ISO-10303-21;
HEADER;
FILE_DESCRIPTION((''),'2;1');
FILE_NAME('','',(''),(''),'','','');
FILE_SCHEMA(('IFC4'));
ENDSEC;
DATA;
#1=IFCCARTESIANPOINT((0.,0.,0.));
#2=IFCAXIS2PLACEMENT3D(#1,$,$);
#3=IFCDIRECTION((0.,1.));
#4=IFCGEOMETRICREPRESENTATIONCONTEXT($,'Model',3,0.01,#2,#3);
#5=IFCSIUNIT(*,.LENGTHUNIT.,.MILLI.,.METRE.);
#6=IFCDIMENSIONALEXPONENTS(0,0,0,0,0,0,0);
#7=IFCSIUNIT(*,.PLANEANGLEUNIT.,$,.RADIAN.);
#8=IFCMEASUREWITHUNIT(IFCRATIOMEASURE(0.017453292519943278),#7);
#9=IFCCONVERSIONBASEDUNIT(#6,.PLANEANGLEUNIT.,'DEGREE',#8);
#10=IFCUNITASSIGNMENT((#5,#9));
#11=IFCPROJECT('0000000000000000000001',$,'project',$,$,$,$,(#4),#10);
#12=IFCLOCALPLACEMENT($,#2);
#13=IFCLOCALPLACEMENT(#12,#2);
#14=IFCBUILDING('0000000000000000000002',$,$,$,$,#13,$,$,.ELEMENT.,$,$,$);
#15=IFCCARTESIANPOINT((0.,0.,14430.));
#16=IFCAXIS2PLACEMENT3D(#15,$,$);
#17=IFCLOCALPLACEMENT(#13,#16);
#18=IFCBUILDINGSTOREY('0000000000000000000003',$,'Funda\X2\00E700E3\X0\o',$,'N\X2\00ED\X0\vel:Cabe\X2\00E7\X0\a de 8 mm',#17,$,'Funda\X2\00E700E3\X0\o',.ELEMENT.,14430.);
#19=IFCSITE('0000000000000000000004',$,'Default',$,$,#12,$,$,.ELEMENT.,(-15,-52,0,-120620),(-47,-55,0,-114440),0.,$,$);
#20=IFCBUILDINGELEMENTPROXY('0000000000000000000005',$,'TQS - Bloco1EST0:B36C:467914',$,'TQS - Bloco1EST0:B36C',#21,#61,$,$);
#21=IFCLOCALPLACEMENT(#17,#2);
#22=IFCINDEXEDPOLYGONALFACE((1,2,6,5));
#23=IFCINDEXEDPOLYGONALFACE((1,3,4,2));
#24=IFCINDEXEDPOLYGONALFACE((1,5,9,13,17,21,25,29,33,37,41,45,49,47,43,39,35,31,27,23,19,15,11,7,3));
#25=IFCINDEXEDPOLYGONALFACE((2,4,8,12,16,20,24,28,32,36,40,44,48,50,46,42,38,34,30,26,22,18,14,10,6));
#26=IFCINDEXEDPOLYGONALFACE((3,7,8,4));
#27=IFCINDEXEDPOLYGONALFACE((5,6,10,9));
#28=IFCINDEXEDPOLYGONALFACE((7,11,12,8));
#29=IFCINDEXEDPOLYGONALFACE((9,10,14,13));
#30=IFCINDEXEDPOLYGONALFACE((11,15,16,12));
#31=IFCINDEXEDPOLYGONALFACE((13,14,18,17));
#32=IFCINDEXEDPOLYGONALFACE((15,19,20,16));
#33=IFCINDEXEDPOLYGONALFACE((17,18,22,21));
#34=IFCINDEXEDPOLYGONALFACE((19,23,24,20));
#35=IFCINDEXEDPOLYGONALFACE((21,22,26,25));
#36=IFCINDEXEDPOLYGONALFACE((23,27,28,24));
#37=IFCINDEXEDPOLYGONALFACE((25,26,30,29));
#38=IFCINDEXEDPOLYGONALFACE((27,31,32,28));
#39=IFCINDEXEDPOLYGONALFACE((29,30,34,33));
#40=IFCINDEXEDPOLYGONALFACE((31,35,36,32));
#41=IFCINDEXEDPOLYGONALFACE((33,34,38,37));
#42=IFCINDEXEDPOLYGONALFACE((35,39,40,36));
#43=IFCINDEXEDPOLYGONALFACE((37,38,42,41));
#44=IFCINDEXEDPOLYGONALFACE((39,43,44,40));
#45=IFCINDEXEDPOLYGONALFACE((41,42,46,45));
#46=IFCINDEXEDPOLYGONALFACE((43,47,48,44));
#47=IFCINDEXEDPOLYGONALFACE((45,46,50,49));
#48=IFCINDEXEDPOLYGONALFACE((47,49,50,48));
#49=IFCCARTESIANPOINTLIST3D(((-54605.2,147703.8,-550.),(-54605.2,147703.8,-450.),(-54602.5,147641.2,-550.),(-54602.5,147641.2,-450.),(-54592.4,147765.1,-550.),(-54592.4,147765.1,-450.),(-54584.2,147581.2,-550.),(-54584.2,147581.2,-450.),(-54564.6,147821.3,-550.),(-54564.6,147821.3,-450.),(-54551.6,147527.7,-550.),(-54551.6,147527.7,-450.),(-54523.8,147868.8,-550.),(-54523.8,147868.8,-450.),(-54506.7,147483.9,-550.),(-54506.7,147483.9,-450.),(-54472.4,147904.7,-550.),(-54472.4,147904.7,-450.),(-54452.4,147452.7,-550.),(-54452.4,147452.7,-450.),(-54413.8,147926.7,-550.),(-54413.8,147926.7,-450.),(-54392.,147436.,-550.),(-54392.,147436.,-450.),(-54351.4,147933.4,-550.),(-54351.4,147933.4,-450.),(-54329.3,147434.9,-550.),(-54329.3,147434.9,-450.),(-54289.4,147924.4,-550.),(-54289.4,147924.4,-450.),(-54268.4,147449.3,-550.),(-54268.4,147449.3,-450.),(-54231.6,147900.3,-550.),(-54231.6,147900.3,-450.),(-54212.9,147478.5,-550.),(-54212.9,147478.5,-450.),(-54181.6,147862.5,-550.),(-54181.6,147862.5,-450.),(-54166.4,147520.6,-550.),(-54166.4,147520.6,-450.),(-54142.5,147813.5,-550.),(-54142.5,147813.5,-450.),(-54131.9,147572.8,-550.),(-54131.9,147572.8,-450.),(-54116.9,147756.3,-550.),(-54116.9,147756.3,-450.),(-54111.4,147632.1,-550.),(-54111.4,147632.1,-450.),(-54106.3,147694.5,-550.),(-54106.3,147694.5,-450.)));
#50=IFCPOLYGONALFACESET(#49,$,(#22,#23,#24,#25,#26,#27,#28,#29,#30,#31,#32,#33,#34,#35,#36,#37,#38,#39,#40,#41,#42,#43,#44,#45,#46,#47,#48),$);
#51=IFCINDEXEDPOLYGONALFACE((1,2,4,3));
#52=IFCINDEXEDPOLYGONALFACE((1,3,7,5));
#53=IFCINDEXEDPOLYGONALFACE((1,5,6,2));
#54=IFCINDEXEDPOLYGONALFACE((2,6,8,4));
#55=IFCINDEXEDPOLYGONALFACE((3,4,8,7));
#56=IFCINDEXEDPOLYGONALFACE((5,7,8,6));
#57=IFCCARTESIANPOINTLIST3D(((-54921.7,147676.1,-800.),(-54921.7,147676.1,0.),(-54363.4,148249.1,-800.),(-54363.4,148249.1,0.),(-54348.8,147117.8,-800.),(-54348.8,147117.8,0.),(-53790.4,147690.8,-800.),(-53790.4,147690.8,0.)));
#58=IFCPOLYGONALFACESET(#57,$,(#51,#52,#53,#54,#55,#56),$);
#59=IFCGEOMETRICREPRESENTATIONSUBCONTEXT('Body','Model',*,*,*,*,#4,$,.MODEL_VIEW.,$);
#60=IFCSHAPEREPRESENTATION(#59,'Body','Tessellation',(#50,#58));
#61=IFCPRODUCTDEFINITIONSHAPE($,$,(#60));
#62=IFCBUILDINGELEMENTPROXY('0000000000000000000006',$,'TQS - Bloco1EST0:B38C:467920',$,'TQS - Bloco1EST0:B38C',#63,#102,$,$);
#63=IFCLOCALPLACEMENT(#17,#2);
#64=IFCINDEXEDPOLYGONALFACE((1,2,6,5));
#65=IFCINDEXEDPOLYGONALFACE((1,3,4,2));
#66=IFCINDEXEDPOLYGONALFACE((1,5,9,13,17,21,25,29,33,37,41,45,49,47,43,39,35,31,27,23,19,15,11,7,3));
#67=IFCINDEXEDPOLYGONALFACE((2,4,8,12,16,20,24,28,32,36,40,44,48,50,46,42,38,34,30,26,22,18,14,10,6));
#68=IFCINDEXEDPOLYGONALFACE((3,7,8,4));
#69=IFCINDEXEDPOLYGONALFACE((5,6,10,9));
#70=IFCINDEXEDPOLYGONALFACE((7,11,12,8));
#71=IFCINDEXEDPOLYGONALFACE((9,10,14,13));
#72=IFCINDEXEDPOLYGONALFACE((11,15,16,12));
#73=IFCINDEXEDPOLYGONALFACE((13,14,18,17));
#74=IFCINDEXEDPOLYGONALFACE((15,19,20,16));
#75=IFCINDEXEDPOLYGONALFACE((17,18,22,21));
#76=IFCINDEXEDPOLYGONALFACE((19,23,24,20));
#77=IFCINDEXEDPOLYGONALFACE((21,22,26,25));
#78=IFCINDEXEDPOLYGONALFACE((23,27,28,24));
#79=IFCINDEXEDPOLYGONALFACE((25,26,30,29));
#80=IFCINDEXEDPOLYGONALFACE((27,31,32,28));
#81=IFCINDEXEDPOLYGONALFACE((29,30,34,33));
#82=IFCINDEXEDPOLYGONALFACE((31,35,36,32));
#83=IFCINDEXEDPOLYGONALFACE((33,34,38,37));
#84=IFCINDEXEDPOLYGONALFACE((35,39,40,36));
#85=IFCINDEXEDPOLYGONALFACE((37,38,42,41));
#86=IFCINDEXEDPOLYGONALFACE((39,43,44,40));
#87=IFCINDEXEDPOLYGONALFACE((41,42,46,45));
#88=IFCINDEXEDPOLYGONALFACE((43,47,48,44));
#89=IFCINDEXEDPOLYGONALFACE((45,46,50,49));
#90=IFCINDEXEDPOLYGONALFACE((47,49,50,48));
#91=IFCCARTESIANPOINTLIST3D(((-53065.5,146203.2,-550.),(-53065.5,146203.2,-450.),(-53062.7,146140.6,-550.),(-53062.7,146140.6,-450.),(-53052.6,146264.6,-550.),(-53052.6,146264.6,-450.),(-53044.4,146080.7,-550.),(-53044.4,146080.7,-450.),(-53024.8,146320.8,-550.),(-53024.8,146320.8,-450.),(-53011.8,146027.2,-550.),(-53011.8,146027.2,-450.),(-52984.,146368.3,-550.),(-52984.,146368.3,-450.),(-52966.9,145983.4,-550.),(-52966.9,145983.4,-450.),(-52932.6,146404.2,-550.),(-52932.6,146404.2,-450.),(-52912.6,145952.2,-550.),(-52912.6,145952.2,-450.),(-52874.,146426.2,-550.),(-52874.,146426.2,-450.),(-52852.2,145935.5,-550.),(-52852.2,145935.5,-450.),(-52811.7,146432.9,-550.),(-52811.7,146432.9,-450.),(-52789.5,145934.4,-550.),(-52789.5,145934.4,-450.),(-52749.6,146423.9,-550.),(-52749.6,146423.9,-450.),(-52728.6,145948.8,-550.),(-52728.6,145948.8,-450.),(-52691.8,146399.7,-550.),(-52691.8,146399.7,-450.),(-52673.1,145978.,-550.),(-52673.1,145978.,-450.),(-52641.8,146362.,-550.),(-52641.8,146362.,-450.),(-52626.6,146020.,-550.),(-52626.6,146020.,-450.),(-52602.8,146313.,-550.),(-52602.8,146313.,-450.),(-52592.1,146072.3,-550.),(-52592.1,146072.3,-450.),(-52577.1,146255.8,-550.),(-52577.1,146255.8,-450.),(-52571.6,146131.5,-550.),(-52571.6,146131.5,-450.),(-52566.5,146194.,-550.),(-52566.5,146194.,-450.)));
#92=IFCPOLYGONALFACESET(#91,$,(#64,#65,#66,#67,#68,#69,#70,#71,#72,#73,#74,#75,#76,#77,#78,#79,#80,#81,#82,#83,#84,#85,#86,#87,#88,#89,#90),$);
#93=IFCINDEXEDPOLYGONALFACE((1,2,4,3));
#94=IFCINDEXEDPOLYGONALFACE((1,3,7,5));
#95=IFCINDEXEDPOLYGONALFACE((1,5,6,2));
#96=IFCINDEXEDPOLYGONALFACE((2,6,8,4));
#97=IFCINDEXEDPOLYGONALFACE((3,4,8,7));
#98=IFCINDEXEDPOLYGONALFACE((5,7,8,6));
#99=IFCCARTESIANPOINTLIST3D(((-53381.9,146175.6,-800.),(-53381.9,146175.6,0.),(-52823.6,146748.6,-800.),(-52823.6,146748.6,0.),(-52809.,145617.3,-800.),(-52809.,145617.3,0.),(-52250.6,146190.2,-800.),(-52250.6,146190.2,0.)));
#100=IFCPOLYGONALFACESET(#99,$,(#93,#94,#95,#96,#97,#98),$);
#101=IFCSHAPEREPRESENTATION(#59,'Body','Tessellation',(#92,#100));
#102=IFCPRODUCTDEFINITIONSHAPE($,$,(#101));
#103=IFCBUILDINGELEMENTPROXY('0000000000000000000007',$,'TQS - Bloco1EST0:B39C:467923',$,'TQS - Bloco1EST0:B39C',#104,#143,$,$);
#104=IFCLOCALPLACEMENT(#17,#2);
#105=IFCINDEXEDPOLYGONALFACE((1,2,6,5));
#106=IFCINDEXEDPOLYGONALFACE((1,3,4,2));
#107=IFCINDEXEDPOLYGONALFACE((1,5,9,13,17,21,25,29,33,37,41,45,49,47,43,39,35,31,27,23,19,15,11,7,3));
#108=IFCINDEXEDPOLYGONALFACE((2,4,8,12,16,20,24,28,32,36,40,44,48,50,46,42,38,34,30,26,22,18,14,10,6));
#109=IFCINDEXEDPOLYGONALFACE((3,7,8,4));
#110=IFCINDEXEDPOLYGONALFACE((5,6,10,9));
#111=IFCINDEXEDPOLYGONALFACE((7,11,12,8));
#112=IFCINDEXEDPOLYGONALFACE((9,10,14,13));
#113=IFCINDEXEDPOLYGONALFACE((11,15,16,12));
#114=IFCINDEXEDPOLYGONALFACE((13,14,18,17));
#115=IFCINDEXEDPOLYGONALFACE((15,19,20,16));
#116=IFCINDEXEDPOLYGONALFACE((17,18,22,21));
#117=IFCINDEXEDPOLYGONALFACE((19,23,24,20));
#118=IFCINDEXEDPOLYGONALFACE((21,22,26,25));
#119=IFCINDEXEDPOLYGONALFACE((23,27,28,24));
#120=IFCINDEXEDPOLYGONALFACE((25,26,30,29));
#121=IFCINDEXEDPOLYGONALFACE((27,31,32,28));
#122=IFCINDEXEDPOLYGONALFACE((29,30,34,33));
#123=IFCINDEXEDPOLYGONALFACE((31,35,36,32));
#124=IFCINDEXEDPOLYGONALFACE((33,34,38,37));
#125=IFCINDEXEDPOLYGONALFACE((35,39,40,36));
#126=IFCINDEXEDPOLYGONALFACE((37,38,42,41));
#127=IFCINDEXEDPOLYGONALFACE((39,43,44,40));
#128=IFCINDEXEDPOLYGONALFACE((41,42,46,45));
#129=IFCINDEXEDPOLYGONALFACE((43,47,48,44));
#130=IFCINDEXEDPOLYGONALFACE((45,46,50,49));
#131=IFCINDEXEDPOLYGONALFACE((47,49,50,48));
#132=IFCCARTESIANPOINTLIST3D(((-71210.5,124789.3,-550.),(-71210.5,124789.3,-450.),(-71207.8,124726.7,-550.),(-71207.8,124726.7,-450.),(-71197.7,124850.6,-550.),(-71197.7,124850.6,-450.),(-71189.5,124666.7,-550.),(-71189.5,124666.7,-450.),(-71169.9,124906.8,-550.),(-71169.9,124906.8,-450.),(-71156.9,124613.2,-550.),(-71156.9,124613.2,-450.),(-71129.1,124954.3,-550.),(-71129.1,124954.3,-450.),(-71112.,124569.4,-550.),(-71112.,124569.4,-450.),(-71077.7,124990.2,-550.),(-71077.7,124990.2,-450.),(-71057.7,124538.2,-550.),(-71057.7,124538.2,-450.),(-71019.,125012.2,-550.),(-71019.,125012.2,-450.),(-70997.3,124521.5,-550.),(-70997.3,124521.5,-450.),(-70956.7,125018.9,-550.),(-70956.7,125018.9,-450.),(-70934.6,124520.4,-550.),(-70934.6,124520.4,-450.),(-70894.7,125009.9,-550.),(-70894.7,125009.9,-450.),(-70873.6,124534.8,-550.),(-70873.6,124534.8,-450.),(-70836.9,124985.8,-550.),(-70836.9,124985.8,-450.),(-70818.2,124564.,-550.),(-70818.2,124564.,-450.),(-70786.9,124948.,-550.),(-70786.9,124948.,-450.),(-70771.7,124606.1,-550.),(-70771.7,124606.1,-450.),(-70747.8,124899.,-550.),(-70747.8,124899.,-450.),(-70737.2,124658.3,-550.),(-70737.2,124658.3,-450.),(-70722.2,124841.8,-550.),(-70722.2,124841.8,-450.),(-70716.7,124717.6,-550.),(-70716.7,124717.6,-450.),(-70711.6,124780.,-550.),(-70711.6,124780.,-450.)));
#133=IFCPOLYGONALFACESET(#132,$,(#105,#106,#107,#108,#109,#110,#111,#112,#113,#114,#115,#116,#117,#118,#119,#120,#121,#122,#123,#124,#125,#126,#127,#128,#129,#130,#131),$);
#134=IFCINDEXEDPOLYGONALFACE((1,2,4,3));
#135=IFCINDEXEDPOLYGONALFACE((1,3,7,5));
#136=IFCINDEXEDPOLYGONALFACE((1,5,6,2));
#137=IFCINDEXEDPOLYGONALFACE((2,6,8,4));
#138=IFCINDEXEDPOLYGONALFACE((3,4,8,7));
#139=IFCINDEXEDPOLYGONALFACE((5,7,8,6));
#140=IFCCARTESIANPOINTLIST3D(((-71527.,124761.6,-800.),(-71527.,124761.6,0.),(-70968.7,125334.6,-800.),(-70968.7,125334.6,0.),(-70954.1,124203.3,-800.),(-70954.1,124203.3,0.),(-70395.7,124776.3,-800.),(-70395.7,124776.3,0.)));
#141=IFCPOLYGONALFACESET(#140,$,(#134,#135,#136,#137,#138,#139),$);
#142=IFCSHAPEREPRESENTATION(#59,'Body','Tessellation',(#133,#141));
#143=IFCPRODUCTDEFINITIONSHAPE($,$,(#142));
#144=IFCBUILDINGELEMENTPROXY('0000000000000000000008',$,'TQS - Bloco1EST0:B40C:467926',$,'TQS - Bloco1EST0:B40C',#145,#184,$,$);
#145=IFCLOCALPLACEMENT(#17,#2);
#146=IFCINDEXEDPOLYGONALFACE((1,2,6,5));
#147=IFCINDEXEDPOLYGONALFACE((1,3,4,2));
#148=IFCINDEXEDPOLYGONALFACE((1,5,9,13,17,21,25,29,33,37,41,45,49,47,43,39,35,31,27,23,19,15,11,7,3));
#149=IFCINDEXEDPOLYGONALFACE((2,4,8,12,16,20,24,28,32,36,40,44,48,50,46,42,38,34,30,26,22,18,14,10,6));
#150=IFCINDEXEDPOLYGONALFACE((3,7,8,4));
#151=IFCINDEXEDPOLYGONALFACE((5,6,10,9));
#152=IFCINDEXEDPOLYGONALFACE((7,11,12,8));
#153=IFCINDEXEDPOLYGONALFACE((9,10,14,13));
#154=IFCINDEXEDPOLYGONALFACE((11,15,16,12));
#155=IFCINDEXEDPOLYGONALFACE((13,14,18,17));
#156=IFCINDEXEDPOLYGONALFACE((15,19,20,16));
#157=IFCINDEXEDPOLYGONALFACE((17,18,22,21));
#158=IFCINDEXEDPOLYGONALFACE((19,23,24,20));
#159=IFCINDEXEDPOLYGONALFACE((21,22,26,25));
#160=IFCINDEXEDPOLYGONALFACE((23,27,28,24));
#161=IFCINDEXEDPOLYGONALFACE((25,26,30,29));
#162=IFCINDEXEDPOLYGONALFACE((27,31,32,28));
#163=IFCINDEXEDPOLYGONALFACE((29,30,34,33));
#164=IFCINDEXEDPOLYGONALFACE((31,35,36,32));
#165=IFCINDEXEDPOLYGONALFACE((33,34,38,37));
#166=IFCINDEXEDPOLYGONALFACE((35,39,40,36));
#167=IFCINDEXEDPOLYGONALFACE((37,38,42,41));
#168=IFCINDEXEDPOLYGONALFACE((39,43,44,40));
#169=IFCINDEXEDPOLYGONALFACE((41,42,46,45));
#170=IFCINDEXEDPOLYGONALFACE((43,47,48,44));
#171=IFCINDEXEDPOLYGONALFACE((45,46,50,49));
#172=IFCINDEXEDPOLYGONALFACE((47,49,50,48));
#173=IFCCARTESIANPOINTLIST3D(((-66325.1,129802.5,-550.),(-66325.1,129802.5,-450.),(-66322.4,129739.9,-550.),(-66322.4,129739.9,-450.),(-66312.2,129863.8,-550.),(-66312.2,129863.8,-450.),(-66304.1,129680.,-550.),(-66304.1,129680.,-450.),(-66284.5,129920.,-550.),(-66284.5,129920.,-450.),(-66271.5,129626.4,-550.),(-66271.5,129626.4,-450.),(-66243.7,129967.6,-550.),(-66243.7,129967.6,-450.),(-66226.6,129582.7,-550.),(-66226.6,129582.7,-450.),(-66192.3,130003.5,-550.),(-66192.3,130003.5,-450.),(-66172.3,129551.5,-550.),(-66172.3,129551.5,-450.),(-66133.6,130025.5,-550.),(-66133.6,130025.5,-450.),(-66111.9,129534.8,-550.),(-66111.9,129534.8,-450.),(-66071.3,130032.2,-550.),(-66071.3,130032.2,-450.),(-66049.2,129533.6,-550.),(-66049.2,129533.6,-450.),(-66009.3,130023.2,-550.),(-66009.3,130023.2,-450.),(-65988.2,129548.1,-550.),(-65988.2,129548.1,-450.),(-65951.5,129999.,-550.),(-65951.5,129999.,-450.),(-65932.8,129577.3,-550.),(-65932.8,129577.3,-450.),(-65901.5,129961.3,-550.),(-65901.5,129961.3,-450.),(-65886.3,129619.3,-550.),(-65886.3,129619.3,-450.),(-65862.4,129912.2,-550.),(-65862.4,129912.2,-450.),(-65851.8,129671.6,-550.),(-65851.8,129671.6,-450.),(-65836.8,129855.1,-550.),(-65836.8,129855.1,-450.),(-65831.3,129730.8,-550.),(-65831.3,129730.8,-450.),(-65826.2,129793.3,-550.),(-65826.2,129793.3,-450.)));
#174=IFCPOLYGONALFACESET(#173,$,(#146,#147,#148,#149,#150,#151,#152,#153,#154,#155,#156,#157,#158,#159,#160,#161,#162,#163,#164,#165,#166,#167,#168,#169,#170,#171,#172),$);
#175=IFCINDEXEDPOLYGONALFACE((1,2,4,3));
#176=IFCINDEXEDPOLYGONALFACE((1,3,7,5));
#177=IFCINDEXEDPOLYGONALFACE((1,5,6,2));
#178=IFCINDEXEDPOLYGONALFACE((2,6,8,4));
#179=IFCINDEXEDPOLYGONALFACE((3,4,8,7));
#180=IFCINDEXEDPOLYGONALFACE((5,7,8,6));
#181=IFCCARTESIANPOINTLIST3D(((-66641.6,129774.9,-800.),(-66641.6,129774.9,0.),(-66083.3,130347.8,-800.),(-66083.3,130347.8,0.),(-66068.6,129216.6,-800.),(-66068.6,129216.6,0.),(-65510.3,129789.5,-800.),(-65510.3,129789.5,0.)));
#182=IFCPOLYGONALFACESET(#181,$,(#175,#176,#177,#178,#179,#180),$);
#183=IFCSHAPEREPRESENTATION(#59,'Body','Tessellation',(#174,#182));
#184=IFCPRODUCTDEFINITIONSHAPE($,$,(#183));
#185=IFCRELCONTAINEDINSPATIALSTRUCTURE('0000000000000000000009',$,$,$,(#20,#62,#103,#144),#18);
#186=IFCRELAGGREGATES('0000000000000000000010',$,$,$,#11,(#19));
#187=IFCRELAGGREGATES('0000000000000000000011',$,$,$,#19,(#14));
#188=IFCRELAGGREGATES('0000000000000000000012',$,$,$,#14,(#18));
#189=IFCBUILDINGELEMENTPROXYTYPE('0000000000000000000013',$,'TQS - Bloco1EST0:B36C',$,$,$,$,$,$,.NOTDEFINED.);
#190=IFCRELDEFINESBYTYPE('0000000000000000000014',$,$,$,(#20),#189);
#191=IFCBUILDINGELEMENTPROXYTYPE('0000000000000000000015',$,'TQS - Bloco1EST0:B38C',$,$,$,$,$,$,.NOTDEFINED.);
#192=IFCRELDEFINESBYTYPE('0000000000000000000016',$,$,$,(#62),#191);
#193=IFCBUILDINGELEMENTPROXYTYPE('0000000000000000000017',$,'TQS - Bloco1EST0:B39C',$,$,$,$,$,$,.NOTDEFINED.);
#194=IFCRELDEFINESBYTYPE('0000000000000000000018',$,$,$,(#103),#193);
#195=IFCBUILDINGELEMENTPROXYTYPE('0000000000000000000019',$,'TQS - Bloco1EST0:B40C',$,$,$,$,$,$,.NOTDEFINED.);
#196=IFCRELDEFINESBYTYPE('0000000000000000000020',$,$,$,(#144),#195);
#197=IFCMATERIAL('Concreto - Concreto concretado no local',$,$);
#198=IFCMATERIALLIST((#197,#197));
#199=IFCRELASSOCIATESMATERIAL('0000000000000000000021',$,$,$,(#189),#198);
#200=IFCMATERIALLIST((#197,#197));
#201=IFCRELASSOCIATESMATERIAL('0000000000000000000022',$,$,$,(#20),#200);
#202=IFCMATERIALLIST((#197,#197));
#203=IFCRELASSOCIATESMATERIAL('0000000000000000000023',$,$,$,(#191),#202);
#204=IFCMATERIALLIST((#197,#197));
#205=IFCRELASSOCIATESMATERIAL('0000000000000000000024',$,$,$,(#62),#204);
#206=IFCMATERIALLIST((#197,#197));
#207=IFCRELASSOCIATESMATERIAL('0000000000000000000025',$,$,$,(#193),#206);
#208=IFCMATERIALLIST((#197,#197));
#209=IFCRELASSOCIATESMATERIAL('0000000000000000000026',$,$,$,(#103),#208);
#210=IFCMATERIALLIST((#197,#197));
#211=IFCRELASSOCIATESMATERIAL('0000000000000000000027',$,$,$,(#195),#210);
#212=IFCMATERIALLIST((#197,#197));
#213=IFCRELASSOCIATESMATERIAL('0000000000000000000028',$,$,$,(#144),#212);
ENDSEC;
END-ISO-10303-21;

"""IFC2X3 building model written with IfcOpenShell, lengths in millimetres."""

from ifc_helpers import new_model, entity, si_unit, converted_unit, direction, frame, frame_2d, origin, origin_2d_with_axis, place, context, subcontext, project, spatial, rectangle, circle, extrude, source, transform, mapped, material, material_list, type_object, type_shapes, element, save


model = new_model("IFC2X3")

# Units and contexts
model_context = context("Model", 3, precision=0.01, world=origin(), true_north=direction((0.0, 1.0)))
body_context = subcontext(model_context, "Body", "Model", "MODEL_VIEW")
ifc_project = project(units=[si_unit("LENGTHUNIT", "METRE", prefix="MILLI"), converted_unit("PLANEANGLEUNIT", "DEGREE", entity("IfcRatioMeasure", 0.017453292519943278), si_unit("PLANEANGLEUNIT", "RADIAN"), dimensions=[0, 0, 0, 0, 0, 0, 0])], contexts=[model_context])

# Site, building, storey
site_placement = place(None, origin())
site = spatial("IfcSite", under=ifc_project, at=site_placement, Name="Default", CompositionType="ELEMENT", RefLatitude=(-15, -52, 0, -120620), RefLongitude=(-47, -55, 0, -114440), RefElevation=0.0)
building_placement = place(site_placement, origin())
building = spatial("IfcBuilding", under=site, at=building_placement, CompositionType="ELEMENT")
storey_placement = place(building_placement, frame((0.0, 0.0, 14430.0)))
storey = spatial("IfcBuildingStorey", under=building, at=storey_placement, Name="Fundação", ObjectType="Nível:Cabeça de 8 mm", LongName="Fundação", CompositionType="ELEMENT", Elevation=14430.0)

# Building element proxies
ifc_material_1 = material(Name="Concreto - Concreto concretado no local")
ifc_material_list_1 = material_list([ifc_material_1, ifc_material_1])
ifc_material_list_2 = material_list([ifc_material_1, ifc_material_1])
building_element_proxy_type_1 = type_object("IfcBuildingElementProxyType", Name="TQS - Bloco1EST0:B36C", PredefinedType="NOTDEFINED", material=ifc_material_list_2)
shared_shape_1 = source(origin(), body_context, "Body", "SweptSolid", [
    extrude(circle(Radius=250.0, at=frame_2d((0.0, 0.0), x_axis=(1.0, 0.0))), frame((0.0, 0.0, -550.0)), (0.0, 0.0, 1.0), 100.0),
    extrude(rectangle(XDim=800.0, YDim=800.0, at=origin_2d_with_axis()), frame((0.0, 0.0, -800.0), z_axis=(0.0, 0.0, 1.0), x_axis=(-1.0, 0.0, 0.0)), (0.0, 0.0, 1.0), 800.0),
])
type_shapes(building_element_proxy_type_1, [shared_shape_1])
proxy_1_placement = place(storey_placement, frame((-54356.1, 147683.4, 0.0), z_axis=(0.0, 0.0, 1.0), x_axis=(0.697915, 0.71618, 0.0)))
element("IfcBuildingElementProxy", 1, at=proxy_1_placement, inside=storey, type_object=building_element_proxy_type_1, material=ifc_material_list_1, Name="TQS - Bloco1EST0:B36C:467914", ObjectType="TQS - Bloco1EST0:B36C", context=body_context, shape_type="MappedRepresentation", body=[
    mapped(shared_shape_1, transform((0.0, 0.0, 0.0), scale=1.0)),
])
ifc_material_list_3 = material_list([ifc_material_1, ifc_material_1])
ifc_material_list_4 = material_list([ifc_material_1, ifc_material_1])
building_element_proxy_type_2 = type_object("IfcBuildingElementProxyType", Name="TQS - Bloco1EST0:B38C", PredefinedType="NOTDEFINED", material=ifc_material_list_4)
shared_shape_2 = source(origin(), body_context, "Body", "SweptSolid", [
    extrude(circle(Radius=250.0, at=frame_2d((0.0, 0.0), x_axis=(1.0, 0.0))), frame((0.0, 0.0, -550.0)), (0.0, 0.0, 1.0), 100.0),
    extrude(rectangle(XDim=800.0, YDim=800.0, at=origin_2d_with_axis()), frame((0.0, 0.0, -800.0), z_axis=(0.0, 0.0, 1.0), x_axis=(-1.0, 0.0, 0.0)), (0.0, 0.0, 1.0), 800.0),
])
type_shapes(building_element_proxy_type_2, [shared_shape_2])
proxy_2_placement = place(storey_placement, frame((-52816.3, 146182.9, 0.0), z_axis=(0.0, 0.0, 1.0), x_axis=(0.697915, 0.71618, 0.0)))
element("IfcBuildingElementProxy", 2, at=proxy_2_placement, inside=storey, type_object=building_element_proxy_type_2, material=ifc_material_list_3, Name="TQS - Bloco1EST0:B38C:467920", ObjectType="TQS - Bloco1EST0:B38C", context=body_context, shape_type="MappedRepresentation", body=[
    mapped(shared_shape_2, transform((0.0, 0.0, 0.0), scale=1.0)),
])
ifc_material_list_5 = material_list([ifc_material_1, ifc_material_1])
ifc_material_list_6 = material_list([ifc_material_1, ifc_material_1])
building_element_proxy_type_3 = type_object("IfcBuildingElementProxyType", Name="TQS - Bloco1EST0:B39C", PredefinedType="NOTDEFINED", material=ifc_material_list_6)
shared_shape_3 = source(origin(), body_context, "Body", "SweptSolid", [
    extrude(circle(Radius=250.0, at=frame_2d((0.0, 0.0), x_axis=(1.0, 0.0))), frame((0.0, 0.0, -550.0)), (0.0, 0.0, 1.0), 100.0),
    extrude(rectangle(XDim=800.0, YDim=800.0, at=origin_2d_with_axis()), frame((0.0, 0.0, -800.0), z_axis=(0.0, 0.0, 1.0), x_axis=(-1.0, 0.0, 0.0)), (0.0, 0.0, 1.0), 800.0),
])
type_shapes(building_element_proxy_type_3, [shared_shape_3])
proxy_3_placement = place(storey_placement, frame((-70961.4, 124768.9, 0.0), z_axis=(0.0, 0.0, 1.0), x_axis=(0.697915, 0.71618, 0.0)))
element("IfcBuildingElementProxy", 3, at=proxy_3_placement, inside=storey, type_object=building_element_proxy_type_3, material=ifc_material_list_5, Name="TQS - Bloco1EST0:B39C:467923", ObjectType="TQS - Bloco1EST0:B39C", context=body_context, shape_type="MappedRepresentation", body=[
    mapped(shared_shape_3, transform((0.0, 0.0, 0.0), scale=1.0)),
])
ifc_material_list_7 = material_list([ifc_material_1, ifc_material_1])
ifc_material_list_8 = material_list([ifc_material_1, ifc_material_1])
building_element_proxy_type_4 = type_object("IfcBuildingElementProxyType", Name="TQS - Bloco1EST0:B40C", PredefinedType="NOTDEFINED", material=ifc_material_list_8)
shared_shape_4 = source(origin(), body_context, "Body", "SweptSolid", [
    extrude(circle(Radius=250.0, at=frame_2d((0.0, 0.0), x_axis=(1.0, 0.0))), frame((0.0, 0.0, -550.0)), (0.0, 0.0, 1.0), 100.0),
    extrude(rectangle(XDim=800.0, YDim=800.0, at=origin_2d_with_axis()), frame((0.0, 0.0, -800.0), z_axis=(0.0, 0.0, 1.0), x_axis=(-1.0, 0.0, 0.0)), (0.0, 0.0, 1.0), 800.0),
])
type_shapes(building_element_proxy_type_4, [shared_shape_4])
proxy_4_placement = place(storey_placement, frame((-66076.0, 129782.2, 0.0), z_axis=(0.0, 0.0, 1.0), x_axis=(0.697915, 0.71618, 0.0)))
element("IfcBuildingElementProxy", 4, at=proxy_4_placement, inside=storey, type_object=building_element_proxy_type_4, material=ifc_material_list_7, Name="TQS - Bloco1EST0:B40C:467926", ObjectType="TQS - Bloco1EST0:B40C", context=body_context, shape_type="MappedRepresentation", body=[
    mapped(shared_shape_4, transform((0.0, 0.0, 0.0), scale=1.0)),
])

save(model, "model.ifc")
